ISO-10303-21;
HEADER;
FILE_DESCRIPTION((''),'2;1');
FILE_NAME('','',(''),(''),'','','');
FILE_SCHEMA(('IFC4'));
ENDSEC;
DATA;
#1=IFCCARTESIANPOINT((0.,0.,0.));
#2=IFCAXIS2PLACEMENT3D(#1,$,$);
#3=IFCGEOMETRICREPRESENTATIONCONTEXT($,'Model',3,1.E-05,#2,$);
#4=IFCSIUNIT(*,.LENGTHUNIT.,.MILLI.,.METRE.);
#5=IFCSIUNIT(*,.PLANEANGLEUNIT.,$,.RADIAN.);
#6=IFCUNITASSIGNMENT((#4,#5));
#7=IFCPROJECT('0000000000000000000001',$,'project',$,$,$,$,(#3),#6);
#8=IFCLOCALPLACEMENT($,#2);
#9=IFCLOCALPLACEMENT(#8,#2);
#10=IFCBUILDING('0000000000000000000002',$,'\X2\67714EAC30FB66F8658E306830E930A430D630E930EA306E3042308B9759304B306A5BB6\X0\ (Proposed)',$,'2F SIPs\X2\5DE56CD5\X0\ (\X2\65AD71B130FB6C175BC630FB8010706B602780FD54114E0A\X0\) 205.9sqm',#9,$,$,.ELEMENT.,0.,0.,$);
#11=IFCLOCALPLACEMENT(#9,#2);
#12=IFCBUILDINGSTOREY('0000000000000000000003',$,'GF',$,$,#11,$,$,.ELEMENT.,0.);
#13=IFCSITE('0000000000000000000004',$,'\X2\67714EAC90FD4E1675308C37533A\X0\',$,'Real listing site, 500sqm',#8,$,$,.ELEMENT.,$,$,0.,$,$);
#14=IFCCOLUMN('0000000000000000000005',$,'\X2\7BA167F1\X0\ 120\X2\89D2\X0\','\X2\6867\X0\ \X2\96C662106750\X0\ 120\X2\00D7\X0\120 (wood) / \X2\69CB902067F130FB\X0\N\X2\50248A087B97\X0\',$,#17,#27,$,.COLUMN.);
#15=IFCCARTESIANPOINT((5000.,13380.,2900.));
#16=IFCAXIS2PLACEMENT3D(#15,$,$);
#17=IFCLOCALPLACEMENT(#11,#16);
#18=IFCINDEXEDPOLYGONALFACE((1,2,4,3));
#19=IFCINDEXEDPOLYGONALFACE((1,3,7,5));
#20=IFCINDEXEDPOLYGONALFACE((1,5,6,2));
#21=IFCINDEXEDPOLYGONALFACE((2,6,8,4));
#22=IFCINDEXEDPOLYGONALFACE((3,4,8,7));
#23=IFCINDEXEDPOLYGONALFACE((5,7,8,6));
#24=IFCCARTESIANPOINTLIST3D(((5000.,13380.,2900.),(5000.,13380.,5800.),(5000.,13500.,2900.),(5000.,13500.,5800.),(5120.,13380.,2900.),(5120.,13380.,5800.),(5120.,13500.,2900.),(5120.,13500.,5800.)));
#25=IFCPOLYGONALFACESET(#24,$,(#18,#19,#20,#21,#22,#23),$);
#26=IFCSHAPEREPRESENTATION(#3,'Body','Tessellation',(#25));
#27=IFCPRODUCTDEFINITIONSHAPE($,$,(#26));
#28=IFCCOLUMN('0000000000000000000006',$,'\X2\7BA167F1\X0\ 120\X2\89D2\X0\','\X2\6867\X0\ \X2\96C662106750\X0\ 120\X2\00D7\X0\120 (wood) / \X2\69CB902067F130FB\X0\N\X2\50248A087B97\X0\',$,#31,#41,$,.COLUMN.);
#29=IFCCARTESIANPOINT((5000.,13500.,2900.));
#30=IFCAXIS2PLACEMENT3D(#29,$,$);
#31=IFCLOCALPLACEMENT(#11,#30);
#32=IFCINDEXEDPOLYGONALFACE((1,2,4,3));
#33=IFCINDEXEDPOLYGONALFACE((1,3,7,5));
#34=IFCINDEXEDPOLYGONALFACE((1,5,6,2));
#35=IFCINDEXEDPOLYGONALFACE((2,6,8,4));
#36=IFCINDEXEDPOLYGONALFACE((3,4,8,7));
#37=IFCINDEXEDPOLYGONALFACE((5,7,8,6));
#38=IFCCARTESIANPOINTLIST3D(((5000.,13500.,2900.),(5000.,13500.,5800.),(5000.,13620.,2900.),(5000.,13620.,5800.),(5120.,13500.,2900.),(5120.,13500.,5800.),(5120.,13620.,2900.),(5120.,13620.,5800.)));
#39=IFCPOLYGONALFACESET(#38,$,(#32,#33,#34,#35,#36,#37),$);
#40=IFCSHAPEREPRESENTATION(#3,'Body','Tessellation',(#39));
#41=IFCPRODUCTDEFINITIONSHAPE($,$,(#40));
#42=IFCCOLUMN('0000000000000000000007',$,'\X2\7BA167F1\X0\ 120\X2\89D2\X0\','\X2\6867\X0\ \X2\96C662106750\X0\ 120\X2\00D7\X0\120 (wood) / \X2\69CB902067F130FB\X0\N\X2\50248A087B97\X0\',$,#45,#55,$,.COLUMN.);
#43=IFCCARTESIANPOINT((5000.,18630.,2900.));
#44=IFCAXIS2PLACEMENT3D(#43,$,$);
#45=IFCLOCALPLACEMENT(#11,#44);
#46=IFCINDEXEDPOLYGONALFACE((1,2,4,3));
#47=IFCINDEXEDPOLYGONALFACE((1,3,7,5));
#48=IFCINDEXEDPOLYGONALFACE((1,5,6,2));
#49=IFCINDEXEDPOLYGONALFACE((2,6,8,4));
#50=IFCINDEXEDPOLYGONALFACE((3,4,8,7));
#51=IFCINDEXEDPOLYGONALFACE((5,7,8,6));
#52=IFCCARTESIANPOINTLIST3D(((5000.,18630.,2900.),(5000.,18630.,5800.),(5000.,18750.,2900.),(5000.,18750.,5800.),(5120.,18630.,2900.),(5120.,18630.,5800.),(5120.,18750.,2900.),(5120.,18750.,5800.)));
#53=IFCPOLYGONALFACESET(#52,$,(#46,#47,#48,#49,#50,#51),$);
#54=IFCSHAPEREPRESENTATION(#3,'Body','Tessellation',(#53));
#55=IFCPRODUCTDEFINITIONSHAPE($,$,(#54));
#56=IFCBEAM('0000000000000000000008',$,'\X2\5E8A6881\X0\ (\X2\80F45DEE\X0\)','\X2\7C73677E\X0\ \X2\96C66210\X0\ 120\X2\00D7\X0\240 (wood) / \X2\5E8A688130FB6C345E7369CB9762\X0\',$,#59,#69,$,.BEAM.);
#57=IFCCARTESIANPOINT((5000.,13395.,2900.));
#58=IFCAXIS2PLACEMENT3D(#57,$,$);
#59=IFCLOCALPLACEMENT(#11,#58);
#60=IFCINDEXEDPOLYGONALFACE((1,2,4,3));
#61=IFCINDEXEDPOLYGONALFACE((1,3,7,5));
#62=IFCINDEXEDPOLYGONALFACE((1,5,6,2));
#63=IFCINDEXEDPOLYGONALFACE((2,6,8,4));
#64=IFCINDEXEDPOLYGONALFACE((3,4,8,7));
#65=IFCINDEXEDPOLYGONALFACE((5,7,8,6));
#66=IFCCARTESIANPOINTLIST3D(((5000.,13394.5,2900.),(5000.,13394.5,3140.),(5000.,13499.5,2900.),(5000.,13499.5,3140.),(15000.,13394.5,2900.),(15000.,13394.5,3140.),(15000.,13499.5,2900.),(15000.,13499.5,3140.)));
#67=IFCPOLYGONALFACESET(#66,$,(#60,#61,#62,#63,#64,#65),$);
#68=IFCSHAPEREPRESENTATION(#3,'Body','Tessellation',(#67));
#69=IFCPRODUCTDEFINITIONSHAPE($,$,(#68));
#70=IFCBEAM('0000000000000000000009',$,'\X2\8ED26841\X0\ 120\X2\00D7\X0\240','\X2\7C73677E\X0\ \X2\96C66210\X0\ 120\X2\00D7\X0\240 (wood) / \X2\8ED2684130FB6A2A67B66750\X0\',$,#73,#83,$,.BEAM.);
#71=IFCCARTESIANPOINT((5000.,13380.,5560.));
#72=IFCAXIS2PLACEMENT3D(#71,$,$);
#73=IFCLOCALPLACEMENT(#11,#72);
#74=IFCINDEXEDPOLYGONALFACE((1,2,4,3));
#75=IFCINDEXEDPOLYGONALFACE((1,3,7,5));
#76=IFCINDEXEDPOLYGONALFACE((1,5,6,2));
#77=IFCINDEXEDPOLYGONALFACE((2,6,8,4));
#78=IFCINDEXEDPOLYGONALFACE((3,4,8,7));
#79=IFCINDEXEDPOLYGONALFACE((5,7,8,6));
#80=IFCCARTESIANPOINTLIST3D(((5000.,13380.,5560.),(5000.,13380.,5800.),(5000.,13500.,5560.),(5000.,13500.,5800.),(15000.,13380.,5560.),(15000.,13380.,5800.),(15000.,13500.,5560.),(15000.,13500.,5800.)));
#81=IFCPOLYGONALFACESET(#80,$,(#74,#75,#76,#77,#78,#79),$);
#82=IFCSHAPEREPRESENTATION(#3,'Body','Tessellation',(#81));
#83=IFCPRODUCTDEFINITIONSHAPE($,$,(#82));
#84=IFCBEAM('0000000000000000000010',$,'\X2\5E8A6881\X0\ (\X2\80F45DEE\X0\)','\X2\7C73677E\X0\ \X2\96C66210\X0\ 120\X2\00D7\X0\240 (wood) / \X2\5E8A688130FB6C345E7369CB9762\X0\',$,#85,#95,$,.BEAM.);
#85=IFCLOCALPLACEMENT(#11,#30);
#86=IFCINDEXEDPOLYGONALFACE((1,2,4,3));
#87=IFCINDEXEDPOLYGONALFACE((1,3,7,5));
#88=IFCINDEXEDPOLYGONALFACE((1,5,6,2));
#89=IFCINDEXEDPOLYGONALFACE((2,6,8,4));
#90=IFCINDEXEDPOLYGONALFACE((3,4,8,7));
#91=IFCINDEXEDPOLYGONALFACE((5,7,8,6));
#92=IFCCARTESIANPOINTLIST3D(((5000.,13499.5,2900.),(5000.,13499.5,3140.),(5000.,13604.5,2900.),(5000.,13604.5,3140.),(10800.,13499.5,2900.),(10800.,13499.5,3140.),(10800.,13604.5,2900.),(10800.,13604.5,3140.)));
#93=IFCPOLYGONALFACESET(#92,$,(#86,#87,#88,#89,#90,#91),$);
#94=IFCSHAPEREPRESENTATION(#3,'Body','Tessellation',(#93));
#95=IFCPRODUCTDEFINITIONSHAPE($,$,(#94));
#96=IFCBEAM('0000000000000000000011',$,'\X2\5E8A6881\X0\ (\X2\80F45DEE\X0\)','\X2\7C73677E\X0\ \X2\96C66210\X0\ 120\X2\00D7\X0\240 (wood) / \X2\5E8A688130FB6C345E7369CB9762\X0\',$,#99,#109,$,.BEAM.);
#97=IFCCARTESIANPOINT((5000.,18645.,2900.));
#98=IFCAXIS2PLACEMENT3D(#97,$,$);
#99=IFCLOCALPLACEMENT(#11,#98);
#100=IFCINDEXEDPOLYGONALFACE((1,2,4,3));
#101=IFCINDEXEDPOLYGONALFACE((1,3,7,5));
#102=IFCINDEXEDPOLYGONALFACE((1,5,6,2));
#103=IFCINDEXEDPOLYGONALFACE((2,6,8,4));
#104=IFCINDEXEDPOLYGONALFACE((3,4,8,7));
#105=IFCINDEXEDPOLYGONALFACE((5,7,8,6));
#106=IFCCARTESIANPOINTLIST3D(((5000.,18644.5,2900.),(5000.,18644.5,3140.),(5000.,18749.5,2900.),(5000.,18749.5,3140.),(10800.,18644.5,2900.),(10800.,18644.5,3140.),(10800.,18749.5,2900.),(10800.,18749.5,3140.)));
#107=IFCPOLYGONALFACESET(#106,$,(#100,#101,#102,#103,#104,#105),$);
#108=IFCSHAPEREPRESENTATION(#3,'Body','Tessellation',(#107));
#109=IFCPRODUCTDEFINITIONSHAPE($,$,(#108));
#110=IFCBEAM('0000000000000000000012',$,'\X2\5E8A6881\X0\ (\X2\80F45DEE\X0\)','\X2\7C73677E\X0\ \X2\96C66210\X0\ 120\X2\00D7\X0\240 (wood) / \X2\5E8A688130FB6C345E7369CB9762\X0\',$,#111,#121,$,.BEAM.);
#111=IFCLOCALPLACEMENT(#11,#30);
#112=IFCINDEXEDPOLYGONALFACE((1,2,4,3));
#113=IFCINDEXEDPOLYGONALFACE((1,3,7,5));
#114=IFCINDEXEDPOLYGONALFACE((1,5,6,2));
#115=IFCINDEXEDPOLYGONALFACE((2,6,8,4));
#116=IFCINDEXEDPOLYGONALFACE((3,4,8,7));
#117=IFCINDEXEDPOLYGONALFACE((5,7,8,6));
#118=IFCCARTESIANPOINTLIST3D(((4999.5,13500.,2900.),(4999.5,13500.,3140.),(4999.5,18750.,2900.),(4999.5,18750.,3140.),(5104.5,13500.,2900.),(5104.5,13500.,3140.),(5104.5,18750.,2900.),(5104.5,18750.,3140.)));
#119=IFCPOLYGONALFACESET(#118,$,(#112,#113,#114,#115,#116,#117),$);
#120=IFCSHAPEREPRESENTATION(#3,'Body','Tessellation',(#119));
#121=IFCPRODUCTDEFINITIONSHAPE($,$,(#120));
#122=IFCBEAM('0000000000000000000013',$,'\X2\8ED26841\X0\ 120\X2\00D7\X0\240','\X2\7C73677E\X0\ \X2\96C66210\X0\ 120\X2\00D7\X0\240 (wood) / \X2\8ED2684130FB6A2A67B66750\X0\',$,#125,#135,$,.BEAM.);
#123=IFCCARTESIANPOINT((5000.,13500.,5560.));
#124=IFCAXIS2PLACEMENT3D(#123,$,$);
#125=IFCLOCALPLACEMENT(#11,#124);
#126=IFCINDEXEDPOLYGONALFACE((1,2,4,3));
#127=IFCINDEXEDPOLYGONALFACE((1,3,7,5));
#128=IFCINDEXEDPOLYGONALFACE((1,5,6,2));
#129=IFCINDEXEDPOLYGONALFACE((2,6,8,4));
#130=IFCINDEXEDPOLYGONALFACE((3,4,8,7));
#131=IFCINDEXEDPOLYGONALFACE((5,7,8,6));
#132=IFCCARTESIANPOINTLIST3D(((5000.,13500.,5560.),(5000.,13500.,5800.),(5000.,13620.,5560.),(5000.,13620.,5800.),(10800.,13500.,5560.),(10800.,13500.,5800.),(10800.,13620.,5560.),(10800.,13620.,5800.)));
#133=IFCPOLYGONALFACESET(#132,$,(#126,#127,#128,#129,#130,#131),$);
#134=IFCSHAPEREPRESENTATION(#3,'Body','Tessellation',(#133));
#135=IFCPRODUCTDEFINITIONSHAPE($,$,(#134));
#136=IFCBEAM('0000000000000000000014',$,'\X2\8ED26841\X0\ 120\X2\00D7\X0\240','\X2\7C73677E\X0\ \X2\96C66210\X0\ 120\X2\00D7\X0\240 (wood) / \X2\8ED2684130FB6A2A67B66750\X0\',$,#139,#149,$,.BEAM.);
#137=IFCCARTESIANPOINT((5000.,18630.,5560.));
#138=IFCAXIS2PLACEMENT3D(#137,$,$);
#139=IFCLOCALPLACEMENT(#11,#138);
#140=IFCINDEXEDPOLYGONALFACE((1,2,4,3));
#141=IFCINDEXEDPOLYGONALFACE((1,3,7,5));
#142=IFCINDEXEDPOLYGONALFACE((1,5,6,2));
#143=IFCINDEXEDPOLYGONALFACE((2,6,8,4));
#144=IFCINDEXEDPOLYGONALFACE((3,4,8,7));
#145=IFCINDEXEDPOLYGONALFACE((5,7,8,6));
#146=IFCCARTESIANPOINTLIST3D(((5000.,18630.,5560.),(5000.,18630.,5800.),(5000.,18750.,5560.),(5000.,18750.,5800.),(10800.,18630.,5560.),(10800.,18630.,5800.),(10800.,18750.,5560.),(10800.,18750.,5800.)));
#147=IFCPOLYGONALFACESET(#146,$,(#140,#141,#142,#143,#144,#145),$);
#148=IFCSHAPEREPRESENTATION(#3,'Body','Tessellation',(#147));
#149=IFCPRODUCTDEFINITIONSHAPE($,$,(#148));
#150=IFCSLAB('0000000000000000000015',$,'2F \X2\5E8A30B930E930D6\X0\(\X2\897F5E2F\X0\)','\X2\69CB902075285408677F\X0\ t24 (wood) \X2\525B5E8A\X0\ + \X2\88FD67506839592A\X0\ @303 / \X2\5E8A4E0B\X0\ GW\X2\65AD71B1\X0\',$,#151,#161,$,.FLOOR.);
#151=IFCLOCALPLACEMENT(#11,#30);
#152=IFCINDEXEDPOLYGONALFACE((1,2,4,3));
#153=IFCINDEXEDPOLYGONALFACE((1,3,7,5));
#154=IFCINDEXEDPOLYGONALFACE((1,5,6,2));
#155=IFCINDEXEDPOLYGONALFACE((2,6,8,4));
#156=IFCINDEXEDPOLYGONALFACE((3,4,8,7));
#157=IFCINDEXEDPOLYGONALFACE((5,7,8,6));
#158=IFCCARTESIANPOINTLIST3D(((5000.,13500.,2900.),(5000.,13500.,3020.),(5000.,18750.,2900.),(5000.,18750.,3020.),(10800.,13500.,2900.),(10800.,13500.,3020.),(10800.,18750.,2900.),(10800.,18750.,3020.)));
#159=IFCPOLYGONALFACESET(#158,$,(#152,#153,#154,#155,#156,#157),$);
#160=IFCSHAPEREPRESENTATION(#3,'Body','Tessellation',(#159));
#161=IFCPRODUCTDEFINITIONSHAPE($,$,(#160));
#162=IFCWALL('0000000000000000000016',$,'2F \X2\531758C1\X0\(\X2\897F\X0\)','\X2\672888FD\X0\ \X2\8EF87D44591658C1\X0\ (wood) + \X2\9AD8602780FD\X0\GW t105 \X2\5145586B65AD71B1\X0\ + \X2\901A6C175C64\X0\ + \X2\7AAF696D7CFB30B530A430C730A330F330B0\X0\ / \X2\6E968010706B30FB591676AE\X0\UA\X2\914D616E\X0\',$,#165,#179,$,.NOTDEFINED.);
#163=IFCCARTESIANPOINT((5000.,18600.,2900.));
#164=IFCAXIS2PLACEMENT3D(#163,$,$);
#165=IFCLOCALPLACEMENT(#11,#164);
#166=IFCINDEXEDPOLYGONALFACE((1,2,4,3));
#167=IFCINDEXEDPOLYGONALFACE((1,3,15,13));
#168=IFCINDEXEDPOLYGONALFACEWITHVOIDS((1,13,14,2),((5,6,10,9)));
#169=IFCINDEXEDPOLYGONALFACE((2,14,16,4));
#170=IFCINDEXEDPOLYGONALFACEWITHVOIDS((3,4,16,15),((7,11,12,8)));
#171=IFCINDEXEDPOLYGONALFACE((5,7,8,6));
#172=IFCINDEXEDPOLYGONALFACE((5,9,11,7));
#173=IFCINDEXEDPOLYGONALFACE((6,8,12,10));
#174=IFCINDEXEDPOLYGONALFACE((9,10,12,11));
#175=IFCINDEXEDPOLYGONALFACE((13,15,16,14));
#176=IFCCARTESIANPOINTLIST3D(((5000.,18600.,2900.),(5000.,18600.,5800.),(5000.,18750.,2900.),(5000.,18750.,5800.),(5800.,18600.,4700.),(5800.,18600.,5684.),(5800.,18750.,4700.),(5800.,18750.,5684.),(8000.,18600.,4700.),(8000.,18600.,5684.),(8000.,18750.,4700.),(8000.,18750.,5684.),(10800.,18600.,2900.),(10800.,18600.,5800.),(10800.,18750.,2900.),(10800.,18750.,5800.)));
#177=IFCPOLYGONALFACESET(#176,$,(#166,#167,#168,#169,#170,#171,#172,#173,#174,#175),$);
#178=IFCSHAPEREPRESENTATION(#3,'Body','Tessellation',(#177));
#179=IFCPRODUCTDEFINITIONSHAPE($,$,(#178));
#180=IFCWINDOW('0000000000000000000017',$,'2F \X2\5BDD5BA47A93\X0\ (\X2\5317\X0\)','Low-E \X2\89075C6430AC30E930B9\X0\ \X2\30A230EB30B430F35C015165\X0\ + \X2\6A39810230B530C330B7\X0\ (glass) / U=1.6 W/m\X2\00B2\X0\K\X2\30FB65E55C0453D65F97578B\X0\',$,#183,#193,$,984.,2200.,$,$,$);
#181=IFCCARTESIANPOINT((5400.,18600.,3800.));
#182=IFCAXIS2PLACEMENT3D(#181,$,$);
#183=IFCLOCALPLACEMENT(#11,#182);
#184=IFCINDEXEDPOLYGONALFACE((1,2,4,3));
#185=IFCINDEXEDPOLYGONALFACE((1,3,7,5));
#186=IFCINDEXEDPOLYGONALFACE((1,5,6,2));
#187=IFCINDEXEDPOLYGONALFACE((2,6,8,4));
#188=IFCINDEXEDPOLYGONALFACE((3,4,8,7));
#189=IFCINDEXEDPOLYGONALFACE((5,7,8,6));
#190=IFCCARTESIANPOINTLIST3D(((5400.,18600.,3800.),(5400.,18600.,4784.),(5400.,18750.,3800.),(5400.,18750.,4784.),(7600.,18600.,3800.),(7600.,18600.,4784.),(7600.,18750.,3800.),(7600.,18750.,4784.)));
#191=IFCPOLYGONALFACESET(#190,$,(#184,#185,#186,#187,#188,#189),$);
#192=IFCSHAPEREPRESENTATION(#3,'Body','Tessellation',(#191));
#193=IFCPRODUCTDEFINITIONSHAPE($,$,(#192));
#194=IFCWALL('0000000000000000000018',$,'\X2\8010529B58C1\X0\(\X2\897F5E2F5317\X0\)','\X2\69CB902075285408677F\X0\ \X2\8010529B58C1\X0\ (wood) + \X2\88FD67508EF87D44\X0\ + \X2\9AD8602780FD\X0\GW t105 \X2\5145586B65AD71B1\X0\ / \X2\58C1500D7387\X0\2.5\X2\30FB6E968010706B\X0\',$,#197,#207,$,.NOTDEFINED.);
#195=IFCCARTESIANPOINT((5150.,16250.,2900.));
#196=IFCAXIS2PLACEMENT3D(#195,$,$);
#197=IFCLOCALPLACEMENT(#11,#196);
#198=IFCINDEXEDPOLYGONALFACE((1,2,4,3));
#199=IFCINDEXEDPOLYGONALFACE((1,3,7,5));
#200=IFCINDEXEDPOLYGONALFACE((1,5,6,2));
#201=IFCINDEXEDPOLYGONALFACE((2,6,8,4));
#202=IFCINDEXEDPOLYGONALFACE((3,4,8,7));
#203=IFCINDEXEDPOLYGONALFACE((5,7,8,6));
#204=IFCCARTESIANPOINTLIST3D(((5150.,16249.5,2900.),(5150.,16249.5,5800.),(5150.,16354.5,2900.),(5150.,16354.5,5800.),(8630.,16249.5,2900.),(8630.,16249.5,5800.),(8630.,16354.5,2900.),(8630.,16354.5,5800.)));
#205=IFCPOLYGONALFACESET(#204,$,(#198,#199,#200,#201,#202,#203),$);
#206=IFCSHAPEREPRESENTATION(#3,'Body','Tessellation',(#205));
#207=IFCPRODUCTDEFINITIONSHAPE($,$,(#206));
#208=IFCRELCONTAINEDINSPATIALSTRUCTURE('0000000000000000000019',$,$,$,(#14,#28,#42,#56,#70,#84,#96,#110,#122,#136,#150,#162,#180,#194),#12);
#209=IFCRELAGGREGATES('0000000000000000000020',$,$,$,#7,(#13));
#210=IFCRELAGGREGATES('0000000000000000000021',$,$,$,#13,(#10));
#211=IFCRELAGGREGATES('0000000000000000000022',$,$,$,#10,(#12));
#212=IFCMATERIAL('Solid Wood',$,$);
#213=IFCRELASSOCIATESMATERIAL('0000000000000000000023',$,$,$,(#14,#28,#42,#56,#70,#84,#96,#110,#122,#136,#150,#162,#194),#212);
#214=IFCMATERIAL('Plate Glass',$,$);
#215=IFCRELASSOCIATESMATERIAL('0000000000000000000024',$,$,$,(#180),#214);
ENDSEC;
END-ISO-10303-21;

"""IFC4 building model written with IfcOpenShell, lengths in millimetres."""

from ifc_helpers import new_model, si_unit, frame, frame_2d, origin, place, context, project, spatial, rectangle, extrude, material, element, fill, save


model = new_model("IFC4")

# Units and contexts
model_context = context("Model", 3, precision=1e-05, world=origin())
ifc_project = project(units=[si_unit("LENGTHUNIT", "METRE", prefix="MILLI"), si_unit("PLANEANGLEUNIT", "RADIAN")], contexts=[model_context])

# Site, building, storey
site_placement = place(None, origin())
site = spatial("IfcSite", under=ifc_project, at=site_placement, Name="東京都世田谷区", ObjectType="Real listing site, 500sqm", CompositionType="ELEMENT", RefElevation=0.0)
building_placement = place(site_placement, origin())
building = spatial("IfcBuilding", under=site, at=building_placement, Name="東京・書斎とライブラリのある静かな家 (Proposed)", ObjectType="2F SIPs工法 (断熱・気密・耐火性能向上) 205.9sqm", CompositionType="ELEMENT", ElevationOfRefHeight=0.0, ElevationOfTerrain=0.0)
storey_placement = place(building_placement, origin())
storey = spatial("IfcBuildingStorey", under=building, at=storey_placement, Name="GF", CompositionType="ELEMENT", Elevation=0.0)

# Columns
ifc_material_1 = material(Name="Solid Wood")
column_1_placement = place(storey_placement, frame((5000.0, 13380.0, 2900.0)))
element("IfcColumn", 1, at=column_1_placement, inside=storey, material=ifc_material_1, Name="管柱 120角", Description="桧 集成材 120×120 (wood) / 構造柱・N値計算", PredefinedType="COLUMN", context=model_context, shape_type="SweptSolid", body=[
    extrude(rectangle(XDim=120.0, YDim=120.0, at=frame_2d((60.0, 60.0))), frame((5000.0, 13380.0, 2900.0)), (0.0, 0.0, 1.0), 2900.0),
])
column_2_placement = place(storey_placement, frame((5000.0, 13500.0, 2900.0)))
element("IfcColumn", 2, at=column_2_placement, inside=storey, material=ifc_material_1, Name="管柱 120角", Description="桧 集成材 120×120 (wood) / 構造柱・N値計算", PredefinedType="COLUMN", context=model_context, shape_type="SweptSolid", body=[
    extrude(rectangle(XDim=120.0, YDim=120.0, at=frame_2d((60.0, 60.0))), frame((5000.0, 13500.0, 2900.0)), (0.0, 0.0, 1.0), 2900.0),
])
column_3_placement = place(storey_placement, frame((5000.0, 18630.0, 2900.0)))
element("IfcColumn", 3, at=column_3_placement, inside=storey, material=ifc_material_1, Name="管柱 120角", Description="桧 集成材 120×120 (wood) / 構造柱・N値計算", PredefinedType="COLUMN", context=model_context, shape_type="SweptSolid", body=[
    extrude(rectangle(XDim=120.0, YDim=120.0, at=frame_2d((60.0, 60.0))), frame((5000.0, 18630.0, 2900.0)), (0.0, 0.0, 1.0), 2900.0),
])

# Beams
beam_1_placement = place(storey_placement, frame((5000.0, 13395.0, 2900.0)))
element("IfcBeam", 4, at=beam_1_placement, inside=storey, material=ifc_material_1, Name="床梁 (胴差)", Description="米松 集成 120×240 (wood) / 床梁・水平構面", PredefinedType="BEAM", context=model_context, shape_type="SweptSolid", body=[
    extrude(rectangle(XDim=10000.0, YDim=105.0, at=frame_2d((5000.0, 52.0))), frame((5000.0, 13395.0, 2900.0)), (0.0, 0.0, 1.0), 240.0),
])
beam_2_placement = place(storey_placement, frame((5000.0, 13380.0, 5560.0)))
element("IfcBeam", 5, at=beam_2_placement, inside=storey, material=ifc_material_1, Name="軒桁 120×240", Description="米松 集成 120×240 (wood) / 軒桁・横架材", PredefinedType="BEAM", context=model_context, shape_type="SweptSolid", body=[
    extrude(rectangle(XDim=10000.0, YDim=120.0, at=frame_2d((5000.0, 60.0))), frame((5000.0, 13380.0, 5560.0)), (0.0, 0.0, 1.0), 240.0),
])
beam_3_placement = place(storey_placement, frame((5000.0, 13500.0, 2900.0)))
element("IfcBeam", 6, at=beam_3_placement, inside=storey, material=ifc_material_1, Name="床梁 (胴差)", Description="米松 集成 120×240 (wood) / 床梁・水平構面", PredefinedType="BEAM", context=model_context, shape_type="SweptSolid", body=[
    extrude(rectangle(XDim=5800.0, YDim=105.0, at=frame_2d((2900.0, 52.0))), frame((5000.0, 13500.0, 2900.0)), (0.0, 0.0, 1.0), 240.0),
])
beam_4_placement = place(storey_placement, frame((5000.0, 18645.0, 2900.0)))
element("IfcBeam", 7, at=beam_4_placement, inside=storey, material=ifc_material_1, Name="床梁 (胴差)", Description="米松 集成 120×240 (wood) / 床梁・水平構面", PredefinedType="BEAM", context=model_context, shape_type="SweptSolid", body=[
    extrude(rectangle(XDim=5800.0, YDim=105.0, at=frame_2d((2900.0, 52.0))), frame((5000.0, 18645.0, 2900.0)), (0.0, 0.0, 1.0), 240.0),
])
beam_5_placement = place(storey_placement, frame((5000.0, 13500.0, 2900.0)))
element("IfcBeam", 8, at=beam_5_placement, inside=storey, material=ifc_material_1, Name="床梁 (胴差)", Description="米松 集成 120×240 (wood) / 床梁・水平構面", PredefinedType="BEAM", context=model_context, shape_type="SweptSolid", body=[
    extrude(rectangle(XDim=105.0, YDim=5250.0, at=frame_2d((52.0, 2625.0))), frame((5000.0, 13500.0, 2900.0)), (0.0, 0.0, 1.0), 240.0),
])
beam_6_placement = place(storey_placement, frame((5000.0, 13500.0, 5560.0)))
element("IfcBeam", 9, at=beam_6_placement, inside=storey, material=ifc_material_1, Name="軒桁 120×240", Description="米松 集成 120×240 (wood) / 軒桁・横架材", PredefinedType="BEAM", context=model_context, shape_type="SweptSolid", body=[
    extrude(rectangle(XDim=5800.0, YDim=120.0, at=frame_2d((2900.0, 60.0))), frame((5000.0, 13500.0, 5560.0)), (0.0, 0.0, 1.0), 240.0),
])
beam_7_placement = place(storey_placement, frame((5000.0, 18630.0, 5560.0)))
element("IfcBeam", 10, at=beam_7_placement, inside=storey, material=ifc_material_1, Name="軒桁 120×240", Description="米松 集成 120×240 (wood) / 軒桁・横架材", PredefinedType="BEAM", context=model_context, shape_type="SweptSolid", body=[
    extrude(rectangle(XDim=5800.0, YDim=120.0, at=frame_2d((2900.0, 60.0))), frame((5000.0, 18630.0, 5560.0)), (0.0, 0.0, 1.0), 240.0),
])

# Slab
slab_placement = place(storey_placement, frame((5000.0, 13500.0, 2900.0)))
element("IfcSlab", 11, at=slab_placement, inside=storey, material=ifc_material_1, Name="2F 床スラブ(西帯)", Description="構造用合板 t24 (wood) 剛床 + 製材根太 @303 / 床下 GW断熱", PredefinedType="FLOOR", context=model_context, shape_type="SweptSolid", body=[
    extrude(rectangle(XDim=5800.0, YDim=5250.0, at=frame_2d((2900.0, 2625.0))), frame((5000.0, 13500.0, 2900.0)), (0.0, 0.0, 1.0), 120.0),
])

# Wall, opening, window
wall_1_placement = place(storey_placement, frame((5000.0, 18600.0, 2900.0)))
wall_1 = element("IfcWall", 12, at=wall_1_placement, inside=storey, material=ifc_material_1, Name="2F 北壁(西)", Description="木製 軸組外壁 (wood) + 高性能GW t105 充填断熱 + 通気層 + 窯業系サイディング / 準耐火・外皮UA配慮", PredefinedType="NOTDEFINED", context=model_context, shape_type="SweptSolid", body=[
    extrude(rectangle(XDim=5800.0, YDim=150.0, at=frame_2d((2900.0, 75.0))), frame((5000.0, 18600.0, 2900.0)), (0.0, 0.0, 1.0), 2900.0),
])
opening_placement = place(storey_placement, frame((5400.0, 18600.0, 3800.0)))
opening = element("IfcOpeningElement", 13, at=opening_placement, cuts=wall_1, PredefinedType="NOTDEFINED", context=model_context, shape_type="SweptSolid", body=[
    extrude(rectangle(XDim=2200.0, YDim=150.0, at=frame_2d((1100.0, 75.0))), frame((5400.0, 18600.0, 3800.0)), (0.0, 0.0, 1.0), 984.0),
])
ifc_material_2 = material(Name="Plate Glass")
window_placement = place(storey_placement, frame((5400.0, 18600.0, 3800.0)))
window = element("IfcWindow", 14, at=window_placement, inside=storey, material=ifc_material_2, Name="2F 寝室窓 (北)", Description="Low-E 複層ガラス アルゴン封入 + 樹脂サッシ (glass) / U=1.6 W/m²K・日射取得型", OverallHeight=984.0, OverallWidth=2200.0, context=model_context, shape_type="SweptSolid", body=[
    extrude(rectangle(XDim=2200.0, YDim=150.0, at=frame_2d((1100.0, 75.0))), frame((5400.0, 18600.0, 3800.0)), (0.0, 0.0, 1.0), 984.0),
])
fill(opening, window)

# Wall
wall_2_placement = place(storey_placement, frame((5150.0, 16250.0, 2900.0)))
element("IfcWall", 15, at=wall_2_placement, inside=storey, material=ifc_material_1, Name="耐力壁(西帯北)", Description="構造用合板 耐力壁 (wood) + 製材軸組 + 高性能GW t105 充填断熱 / 壁倍率2.5・準耐火", PredefinedType="NOTDEFINED", context=model_context, shape_type="SweptSolid", body=[
    extrude(rectangle(XDim=3480.0, YDim=105.0, at=frame_2d((1740.0, 52.0))), frame((5150.0, 16250.0, 2900.0)), (0.0, 0.0, 1.0), 2900.0),
])

save(model, "model.ifc")
